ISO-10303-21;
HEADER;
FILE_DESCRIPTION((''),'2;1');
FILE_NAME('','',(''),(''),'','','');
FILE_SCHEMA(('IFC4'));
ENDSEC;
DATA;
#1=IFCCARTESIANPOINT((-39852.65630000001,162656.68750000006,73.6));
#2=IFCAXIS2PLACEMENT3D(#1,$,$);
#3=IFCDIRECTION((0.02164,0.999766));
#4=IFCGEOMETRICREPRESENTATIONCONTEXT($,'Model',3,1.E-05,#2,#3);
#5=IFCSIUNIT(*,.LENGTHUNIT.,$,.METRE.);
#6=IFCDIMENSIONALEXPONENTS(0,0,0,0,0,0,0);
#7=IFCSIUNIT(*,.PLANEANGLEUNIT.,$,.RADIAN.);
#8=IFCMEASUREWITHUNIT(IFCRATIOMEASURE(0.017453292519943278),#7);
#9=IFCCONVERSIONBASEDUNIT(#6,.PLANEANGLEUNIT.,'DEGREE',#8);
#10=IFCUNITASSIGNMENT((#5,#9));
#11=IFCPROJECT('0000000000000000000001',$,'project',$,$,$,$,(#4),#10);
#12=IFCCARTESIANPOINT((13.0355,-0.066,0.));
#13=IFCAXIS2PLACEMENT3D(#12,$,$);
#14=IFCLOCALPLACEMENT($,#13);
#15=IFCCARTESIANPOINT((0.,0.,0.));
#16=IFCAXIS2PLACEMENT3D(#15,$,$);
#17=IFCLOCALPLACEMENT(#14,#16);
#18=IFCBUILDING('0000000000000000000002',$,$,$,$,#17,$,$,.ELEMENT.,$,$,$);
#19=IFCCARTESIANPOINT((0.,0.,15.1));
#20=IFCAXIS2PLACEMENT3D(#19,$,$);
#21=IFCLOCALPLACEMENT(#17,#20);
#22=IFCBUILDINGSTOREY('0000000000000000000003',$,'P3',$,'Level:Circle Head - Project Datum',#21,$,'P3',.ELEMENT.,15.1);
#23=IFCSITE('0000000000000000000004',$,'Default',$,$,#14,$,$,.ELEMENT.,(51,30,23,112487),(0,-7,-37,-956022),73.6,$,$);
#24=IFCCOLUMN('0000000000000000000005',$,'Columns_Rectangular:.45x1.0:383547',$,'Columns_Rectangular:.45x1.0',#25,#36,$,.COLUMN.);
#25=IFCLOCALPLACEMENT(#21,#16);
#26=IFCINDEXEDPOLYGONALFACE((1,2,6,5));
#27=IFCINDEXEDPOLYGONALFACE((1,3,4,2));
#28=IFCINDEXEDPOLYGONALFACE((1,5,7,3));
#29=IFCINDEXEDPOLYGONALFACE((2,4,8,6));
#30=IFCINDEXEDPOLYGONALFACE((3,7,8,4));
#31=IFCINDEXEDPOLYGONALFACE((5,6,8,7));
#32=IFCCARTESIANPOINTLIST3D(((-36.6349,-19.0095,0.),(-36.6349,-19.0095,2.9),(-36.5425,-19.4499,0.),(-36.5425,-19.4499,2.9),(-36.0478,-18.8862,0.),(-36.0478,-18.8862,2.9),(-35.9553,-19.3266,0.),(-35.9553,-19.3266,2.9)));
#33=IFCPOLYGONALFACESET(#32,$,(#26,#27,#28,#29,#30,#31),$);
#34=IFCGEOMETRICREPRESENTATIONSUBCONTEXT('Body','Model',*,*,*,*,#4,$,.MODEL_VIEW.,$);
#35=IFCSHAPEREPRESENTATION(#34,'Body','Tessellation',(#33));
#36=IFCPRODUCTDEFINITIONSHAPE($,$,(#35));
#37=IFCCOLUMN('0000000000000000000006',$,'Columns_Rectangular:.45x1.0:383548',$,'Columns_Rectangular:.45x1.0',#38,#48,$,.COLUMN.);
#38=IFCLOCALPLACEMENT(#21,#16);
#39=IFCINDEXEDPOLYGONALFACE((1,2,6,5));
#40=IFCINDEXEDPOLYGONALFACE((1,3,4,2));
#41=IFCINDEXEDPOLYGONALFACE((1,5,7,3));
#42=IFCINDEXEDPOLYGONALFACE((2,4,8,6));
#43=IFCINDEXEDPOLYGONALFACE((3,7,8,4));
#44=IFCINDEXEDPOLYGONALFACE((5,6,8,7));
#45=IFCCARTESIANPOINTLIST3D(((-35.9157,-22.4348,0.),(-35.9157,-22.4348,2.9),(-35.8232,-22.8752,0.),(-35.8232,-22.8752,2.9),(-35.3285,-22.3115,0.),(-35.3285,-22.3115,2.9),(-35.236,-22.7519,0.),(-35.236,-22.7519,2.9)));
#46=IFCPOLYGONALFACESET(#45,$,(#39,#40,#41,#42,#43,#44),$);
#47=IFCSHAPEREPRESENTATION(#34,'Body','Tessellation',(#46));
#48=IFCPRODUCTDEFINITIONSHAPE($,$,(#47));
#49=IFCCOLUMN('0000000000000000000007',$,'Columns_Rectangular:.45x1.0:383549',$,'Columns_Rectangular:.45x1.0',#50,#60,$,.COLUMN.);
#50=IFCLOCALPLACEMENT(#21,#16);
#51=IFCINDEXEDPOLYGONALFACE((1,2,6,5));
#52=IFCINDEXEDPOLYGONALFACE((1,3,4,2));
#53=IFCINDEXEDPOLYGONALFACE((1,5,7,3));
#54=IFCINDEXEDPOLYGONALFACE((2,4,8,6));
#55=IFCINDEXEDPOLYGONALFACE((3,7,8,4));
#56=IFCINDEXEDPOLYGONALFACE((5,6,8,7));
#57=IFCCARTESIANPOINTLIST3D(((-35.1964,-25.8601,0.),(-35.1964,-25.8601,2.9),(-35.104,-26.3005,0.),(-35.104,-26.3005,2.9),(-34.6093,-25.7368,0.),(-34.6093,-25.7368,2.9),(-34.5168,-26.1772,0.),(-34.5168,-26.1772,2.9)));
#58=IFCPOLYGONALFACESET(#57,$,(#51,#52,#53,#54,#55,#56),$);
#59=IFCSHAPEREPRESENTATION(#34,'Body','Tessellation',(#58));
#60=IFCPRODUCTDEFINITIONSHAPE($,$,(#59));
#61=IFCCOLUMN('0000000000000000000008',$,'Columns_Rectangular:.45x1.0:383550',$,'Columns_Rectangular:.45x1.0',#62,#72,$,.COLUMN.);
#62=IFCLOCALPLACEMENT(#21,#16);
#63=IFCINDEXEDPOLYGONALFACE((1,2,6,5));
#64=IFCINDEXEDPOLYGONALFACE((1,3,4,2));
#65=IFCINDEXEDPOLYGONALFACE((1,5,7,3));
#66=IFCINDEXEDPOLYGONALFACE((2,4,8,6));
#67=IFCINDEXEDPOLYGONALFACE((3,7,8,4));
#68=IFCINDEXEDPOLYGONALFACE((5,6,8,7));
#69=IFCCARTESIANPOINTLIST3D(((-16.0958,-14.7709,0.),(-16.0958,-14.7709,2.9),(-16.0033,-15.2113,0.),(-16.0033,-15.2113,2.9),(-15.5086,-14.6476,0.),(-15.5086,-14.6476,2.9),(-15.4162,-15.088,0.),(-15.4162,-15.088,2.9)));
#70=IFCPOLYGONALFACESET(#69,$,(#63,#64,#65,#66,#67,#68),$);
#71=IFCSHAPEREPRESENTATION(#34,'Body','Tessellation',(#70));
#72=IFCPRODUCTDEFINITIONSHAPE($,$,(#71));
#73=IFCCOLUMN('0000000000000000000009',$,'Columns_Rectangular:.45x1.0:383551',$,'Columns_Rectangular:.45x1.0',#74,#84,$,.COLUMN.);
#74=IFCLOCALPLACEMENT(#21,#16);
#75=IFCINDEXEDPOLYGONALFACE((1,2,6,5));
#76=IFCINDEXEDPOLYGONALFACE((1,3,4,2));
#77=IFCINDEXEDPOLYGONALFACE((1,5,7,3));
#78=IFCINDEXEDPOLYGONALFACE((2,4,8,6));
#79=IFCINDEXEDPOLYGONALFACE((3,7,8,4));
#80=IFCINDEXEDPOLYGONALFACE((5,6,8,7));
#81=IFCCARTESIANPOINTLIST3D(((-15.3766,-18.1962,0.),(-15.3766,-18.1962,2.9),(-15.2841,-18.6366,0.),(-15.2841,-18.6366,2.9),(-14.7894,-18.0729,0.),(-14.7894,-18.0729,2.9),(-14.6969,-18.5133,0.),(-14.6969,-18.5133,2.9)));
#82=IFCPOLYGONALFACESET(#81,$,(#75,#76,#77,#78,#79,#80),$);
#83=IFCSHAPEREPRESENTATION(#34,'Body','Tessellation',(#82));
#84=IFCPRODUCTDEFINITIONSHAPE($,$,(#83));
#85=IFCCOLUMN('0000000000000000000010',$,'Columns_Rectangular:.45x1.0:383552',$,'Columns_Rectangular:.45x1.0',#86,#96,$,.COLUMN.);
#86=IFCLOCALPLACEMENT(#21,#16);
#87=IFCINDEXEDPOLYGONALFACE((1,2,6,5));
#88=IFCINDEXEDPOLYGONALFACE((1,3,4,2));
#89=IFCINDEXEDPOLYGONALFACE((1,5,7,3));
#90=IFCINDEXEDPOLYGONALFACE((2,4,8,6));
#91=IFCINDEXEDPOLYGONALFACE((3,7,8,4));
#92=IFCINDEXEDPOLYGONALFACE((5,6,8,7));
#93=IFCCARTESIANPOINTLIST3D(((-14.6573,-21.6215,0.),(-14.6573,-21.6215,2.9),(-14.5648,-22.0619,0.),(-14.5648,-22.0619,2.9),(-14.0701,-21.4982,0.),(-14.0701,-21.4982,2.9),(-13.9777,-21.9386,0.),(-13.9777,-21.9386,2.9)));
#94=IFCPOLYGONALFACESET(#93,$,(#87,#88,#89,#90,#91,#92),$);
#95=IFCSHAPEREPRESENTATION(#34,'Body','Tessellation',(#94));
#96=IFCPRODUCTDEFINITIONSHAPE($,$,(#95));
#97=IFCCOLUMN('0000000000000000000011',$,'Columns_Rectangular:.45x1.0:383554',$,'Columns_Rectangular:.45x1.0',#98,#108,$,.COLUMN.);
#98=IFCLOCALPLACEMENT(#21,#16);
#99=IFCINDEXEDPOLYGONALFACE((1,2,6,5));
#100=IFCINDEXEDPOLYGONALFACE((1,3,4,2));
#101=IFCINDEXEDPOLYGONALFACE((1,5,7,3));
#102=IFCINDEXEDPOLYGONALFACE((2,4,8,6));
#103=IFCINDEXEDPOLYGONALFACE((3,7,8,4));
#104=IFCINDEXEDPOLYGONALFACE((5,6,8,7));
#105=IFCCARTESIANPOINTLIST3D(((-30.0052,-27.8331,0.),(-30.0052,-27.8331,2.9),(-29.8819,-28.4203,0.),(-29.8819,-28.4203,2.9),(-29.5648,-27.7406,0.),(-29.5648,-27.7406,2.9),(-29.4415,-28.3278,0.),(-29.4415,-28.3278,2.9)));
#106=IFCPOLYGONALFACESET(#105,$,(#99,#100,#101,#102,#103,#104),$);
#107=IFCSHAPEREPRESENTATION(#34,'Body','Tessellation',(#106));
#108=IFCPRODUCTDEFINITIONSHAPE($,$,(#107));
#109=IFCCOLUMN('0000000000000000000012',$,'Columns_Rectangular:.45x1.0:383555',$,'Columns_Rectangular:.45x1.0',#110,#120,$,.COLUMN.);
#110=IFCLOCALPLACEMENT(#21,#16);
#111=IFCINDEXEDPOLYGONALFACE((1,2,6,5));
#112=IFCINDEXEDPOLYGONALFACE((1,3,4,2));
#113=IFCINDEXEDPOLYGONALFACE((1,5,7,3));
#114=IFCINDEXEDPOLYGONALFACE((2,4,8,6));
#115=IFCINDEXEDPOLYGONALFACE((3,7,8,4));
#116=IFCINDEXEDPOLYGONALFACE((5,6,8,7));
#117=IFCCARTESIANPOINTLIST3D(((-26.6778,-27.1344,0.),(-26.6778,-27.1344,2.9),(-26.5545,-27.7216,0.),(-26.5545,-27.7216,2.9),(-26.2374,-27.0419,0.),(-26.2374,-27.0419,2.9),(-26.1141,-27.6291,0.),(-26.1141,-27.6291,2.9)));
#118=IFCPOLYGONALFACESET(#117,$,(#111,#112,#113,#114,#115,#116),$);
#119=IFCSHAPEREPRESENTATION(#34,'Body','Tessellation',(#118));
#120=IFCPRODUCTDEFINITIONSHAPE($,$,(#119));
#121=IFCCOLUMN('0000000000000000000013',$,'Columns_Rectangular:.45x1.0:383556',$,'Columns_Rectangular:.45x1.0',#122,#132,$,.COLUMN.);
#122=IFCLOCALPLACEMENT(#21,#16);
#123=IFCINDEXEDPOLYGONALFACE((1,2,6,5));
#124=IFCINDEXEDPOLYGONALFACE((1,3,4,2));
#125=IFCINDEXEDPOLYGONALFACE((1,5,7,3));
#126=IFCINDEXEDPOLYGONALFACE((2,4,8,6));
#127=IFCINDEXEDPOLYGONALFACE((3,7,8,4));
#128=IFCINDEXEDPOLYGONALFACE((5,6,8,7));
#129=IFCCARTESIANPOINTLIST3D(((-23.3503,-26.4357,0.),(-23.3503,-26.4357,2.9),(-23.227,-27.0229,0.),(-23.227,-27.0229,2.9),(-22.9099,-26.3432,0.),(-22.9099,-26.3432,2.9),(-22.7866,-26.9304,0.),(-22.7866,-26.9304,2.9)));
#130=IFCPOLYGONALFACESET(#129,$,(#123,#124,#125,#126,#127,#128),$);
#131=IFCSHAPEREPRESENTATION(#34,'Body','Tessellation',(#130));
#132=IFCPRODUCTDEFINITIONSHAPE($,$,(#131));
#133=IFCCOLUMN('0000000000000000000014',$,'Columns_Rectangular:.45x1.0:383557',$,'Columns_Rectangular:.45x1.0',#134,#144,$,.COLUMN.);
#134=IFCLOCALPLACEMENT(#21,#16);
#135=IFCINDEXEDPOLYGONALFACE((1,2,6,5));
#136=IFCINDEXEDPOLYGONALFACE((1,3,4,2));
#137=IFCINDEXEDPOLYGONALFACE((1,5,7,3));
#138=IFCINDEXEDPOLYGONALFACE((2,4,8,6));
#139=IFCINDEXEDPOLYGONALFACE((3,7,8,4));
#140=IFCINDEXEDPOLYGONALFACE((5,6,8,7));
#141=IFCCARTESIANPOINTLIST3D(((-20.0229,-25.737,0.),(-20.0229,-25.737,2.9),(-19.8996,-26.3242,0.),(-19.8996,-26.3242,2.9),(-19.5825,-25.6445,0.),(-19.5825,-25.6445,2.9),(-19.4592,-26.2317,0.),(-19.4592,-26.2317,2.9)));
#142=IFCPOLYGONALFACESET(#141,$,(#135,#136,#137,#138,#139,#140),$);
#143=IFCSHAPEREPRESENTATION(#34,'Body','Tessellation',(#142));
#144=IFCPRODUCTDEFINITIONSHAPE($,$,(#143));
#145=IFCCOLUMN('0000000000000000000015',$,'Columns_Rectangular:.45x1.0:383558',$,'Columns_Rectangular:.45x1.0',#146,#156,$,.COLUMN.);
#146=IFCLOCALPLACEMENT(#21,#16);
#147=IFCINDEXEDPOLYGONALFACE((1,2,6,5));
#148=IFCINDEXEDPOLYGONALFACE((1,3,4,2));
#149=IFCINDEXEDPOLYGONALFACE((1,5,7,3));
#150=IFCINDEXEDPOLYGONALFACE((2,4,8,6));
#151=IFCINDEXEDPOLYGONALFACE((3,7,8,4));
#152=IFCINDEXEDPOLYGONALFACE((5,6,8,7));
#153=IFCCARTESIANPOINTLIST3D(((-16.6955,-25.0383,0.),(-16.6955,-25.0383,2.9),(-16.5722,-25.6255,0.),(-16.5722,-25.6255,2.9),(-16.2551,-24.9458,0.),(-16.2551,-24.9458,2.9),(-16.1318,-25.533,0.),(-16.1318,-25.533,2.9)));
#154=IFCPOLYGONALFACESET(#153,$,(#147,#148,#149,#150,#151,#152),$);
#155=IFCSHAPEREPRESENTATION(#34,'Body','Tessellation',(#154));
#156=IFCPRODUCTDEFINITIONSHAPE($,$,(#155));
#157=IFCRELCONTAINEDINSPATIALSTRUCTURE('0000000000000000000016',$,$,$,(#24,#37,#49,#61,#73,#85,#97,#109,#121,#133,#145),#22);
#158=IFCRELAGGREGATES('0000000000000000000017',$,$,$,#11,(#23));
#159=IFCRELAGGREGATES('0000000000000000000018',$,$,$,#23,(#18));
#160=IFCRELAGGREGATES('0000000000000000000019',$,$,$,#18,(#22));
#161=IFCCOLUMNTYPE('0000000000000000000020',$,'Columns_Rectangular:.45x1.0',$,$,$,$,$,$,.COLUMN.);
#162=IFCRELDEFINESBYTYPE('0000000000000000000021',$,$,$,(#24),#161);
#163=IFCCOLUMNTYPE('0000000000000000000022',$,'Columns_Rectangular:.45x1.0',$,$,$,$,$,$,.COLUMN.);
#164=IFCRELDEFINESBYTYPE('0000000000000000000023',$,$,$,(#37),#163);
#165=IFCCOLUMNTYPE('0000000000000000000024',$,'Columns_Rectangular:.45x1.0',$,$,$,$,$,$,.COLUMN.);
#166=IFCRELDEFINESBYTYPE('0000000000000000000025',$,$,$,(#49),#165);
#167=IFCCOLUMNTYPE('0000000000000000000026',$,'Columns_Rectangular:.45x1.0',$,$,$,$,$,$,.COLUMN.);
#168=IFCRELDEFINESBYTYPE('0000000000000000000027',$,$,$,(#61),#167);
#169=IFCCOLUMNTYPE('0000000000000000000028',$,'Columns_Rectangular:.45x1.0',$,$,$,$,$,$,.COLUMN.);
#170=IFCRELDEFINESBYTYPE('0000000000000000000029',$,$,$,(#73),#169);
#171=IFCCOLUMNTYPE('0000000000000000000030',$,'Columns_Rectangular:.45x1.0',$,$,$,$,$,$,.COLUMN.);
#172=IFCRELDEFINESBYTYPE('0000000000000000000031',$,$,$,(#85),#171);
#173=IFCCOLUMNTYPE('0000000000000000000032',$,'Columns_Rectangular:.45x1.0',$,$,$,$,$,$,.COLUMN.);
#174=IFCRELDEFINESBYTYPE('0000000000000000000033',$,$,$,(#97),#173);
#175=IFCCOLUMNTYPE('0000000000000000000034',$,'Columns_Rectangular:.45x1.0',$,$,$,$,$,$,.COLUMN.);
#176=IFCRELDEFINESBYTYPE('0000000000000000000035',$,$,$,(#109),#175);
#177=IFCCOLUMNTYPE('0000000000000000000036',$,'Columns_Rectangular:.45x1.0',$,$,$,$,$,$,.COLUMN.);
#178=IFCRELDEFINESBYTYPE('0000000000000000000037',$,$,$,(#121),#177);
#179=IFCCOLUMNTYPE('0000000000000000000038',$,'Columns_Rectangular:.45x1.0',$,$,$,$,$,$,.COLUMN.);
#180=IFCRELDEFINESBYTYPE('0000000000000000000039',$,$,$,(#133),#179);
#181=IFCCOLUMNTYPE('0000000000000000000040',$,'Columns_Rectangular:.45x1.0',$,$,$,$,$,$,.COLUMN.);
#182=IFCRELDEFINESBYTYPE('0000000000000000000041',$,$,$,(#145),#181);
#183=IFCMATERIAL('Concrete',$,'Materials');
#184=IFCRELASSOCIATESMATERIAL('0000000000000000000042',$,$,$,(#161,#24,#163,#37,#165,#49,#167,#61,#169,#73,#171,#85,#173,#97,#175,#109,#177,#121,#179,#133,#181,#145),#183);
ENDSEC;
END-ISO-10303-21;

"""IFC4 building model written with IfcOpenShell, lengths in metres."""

from ifc_helpers import new_model, entity, si_unit, converted_unit, direction, frame, origin, place, context, subcontext, project, spatial, indexed_curve, outline, extrude, source, transform, mapped, material, type_object, type_shapes, element, save


model = new_model("IFC4")

# Units and contexts
model_context = context("Model", 3, precision=1e-05, world=frame((-39852.65630000001, 162656.68750000006, 73.6)), true_north=direction((0.02164, 0.999766)))
body_context = subcontext(model_context, "Body", "Model", "MODEL_VIEW")
ifc_project = project(units=[si_unit("LENGTHUNIT", "METRE"), converted_unit("PLANEANGLEUNIT", "DEGREE", entity("IfcRatioMeasure", 0.017453292519943278), si_unit("PLANEANGLEUNIT", "RADIAN"), dimensions=[0, 0, 0, 0, 0, 0, 0])], contexts=[model_context])

# Site, building, storey
site_placement = place(None, frame((13.0355, -0.066, 0.0)))
site = spatial("IfcSite", under=ifc_project, at=site_placement, Name="Default", CompositionType="ELEMENT", RefLatitude=(51, 30, 23, 112487), RefLongitude=(0, -7, -37, -956022), RefElevation=73.6)
building_placement = place(site_placement, origin())
building = spatial("IfcBuilding", under=site, at=building_placement, CompositionType="ELEMENT")
storey_placement = place(building_placement, frame((0.0, 0.0, 15.1)))
storey = spatial("IfcBuildingStorey", under=building, at=storey_placement, Name="P3", ObjectType="Level:Circle Head - Project Datum", LongName="P3", CompositionType="ELEMENT", Elevation=15.1)

# Columns
ifc_material = material(Name="Concrete", Category="Materials")
column_type_1 = type_object("IfcColumnType", Name="Columns_Rectangular:.45x1.0", PredefinedType="COLUMN", material=ifc_material)
shared_shape_1 = source(origin(), body_context, "Body", "SweptSolid", [
    extrude(outline(indexed_curve([(-0.3, -0.225), (0.3, -0.225), (0.3, 0.225), (-0.3, 0.225), (-0.3, -0.225)], self_intersect=False)), frame((-36.2951, -19.168, 15.1), z_axis=(0.0, 0.0, 1.0), x_axis=(-0.978657, -0.2055, 0.0)), (0.0, 0.0, 1.0), 2.9),
])
type_shapes(column_type_1, [shared_shape_1])
column_1_placement = place(storey_placement, frame((0.0, 0.0, -15.1)))
element("IfcColumn", 1, at=column_1_placement, inside=storey, type_object=column_type_1, material=ifc_material, Name="Columns_Rectangular:.45x1.0:383547", ObjectType="Columns_Rectangular:.45x1.0", PredefinedType="COLUMN", context=body_context, shape_type="MappedRepresentation", body=[
    mapped(shared_shape_1, transform((0.0, 0.0, 0.0), scale=1.0)),
])
column_type_2 = type_object("IfcColumnType", Name="Columns_Rectangular:.45x1.0", PredefinedType="COLUMN", material=ifc_material)
shared_shape_2 = source(origin(), body_context, "Body", "SweptSolid", [
    extrude(outline(indexed_curve([(-0.3, -0.225), (0.3, -0.225), (0.3, 0.225), (-0.3, 0.225), (-0.3, -0.225)], self_intersect=False)), frame((-35.5759, -22.5933, 15.1), z_axis=(0.0, 0.0, 1.0), x_axis=(-0.978657, -0.2055, 0.0)), (0.0, 0.0, 1.0), 2.9),
])
type_shapes(column_type_2, [shared_shape_2])
column_2_placement = place(storey_placement, frame((0.0, 0.0, -15.1)))
element("IfcColumn", 2, at=column_2_placement, inside=storey, type_object=column_type_2, material=ifc_material, Name="Columns_Rectangular:.45x1.0:383548", ObjectType="Columns_Rectangular:.45x1.0", PredefinedType="COLUMN", context=body_context, shape_type="MappedRepresentation", body=[
    mapped(shared_shape_2, transform((0.0, 0.0, 0.0), scale=1.0)),
])
column_type_3 = type_object("IfcColumnType", Name="Columns_Rectangular:.45x1.0", PredefinedType="COLUMN", material=ifc_material)
shared_shape_3 = source(origin(), body_context, "Body", "SweptSolid", [
    extrude(outline(indexed_curve([(-0.3, -0.225), (0.3, -0.225), (0.3, 0.225), (-0.3, 0.225), (-0.3, -0.225)], self_intersect=False)), frame((-34.8566, -26.0186, 15.1), z_axis=(0.0, 0.0, 1.0), x_axis=(-0.978657, -0.2055, 0.0)), (0.0, 0.0, 1.0), 2.9),
])
type_shapes(column_type_3, [shared_shape_3])
column_3_placement = place(storey_placement, frame((0.0, 0.0, -15.1)))
element("IfcColumn", 3, at=column_3_placement, inside=storey, type_object=column_type_3, material=ifc_material, Name="Columns_Rectangular:.45x1.0:383549", ObjectType="Columns_Rectangular:.45x1.0", PredefinedType="COLUMN", context=body_context, shape_type="MappedRepresentation", body=[
    mapped(shared_shape_3, transform((0.0, 0.0, 0.0), scale=1.0)),
])
column_type_4 = type_object("IfcColumnType", Name="Columns_Rectangular:.45x1.0", PredefinedType="COLUMN", material=ifc_material)
shared_shape_4 = source(origin(), body_context, "Body", "SweptSolid", [
    extrude(outline(indexed_curve([(-0.3, -0.225), (0.3, -0.225), (0.3, 0.225), (-0.3, 0.225), (-0.3, -0.225)], self_intersect=False)), frame((-15.756, -14.9295, 15.1), z_axis=(0.0, 0.0, 1.0), x_axis=(-0.978657, -0.2055, 0.0)), (0.0, 0.0, 1.0), 2.9),
])
type_shapes(column_type_4, [shared_shape_4])
column_4_placement = place(storey_placement, frame((0.0, 0.0, -15.1)))
element("IfcColumn", 4, at=column_4_placement, inside=storey, type_object=column_type_4, material=ifc_material, Name="Columns_Rectangular:.45x1.0:383550", ObjectType="Columns_Rectangular:.45x1.0", PredefinedType="COLUMN", context=body_context, shape_type="MappedRepresentation", body=[
    mapped(shared_shape_4, transform((0.0, 0.0, 0.0), scale=1.0)),
])
column_type_5 = type_object("IfcColumnType", Name="Columns_Rectangular:.45x1.0", PredefinedType="COLUMN", material=ifc_material)
shared_shape_5 = source(origin(), body_context, "Body", "SweptSolid", [
    extrude(outline(indexed_curve([(-0.3, -0.225), (0.3, -0.225), (0.3, 0.225), (-0.3, 0.225), (-0.3, -0.225)], self_intersect=False)), frame((-15.0367, -18.3548, 15.1), z_axis=(0.0, 0.0, 1.0), x_axis=(-0.978657, -0.2055, 0.0)), (0.0, 0.0, 1.0), 2.9),
])
type_shapes(column_type_5, [shared_shape_5])
column_5_placement = place(storey_placement, frame((0.0, 0.0, -15.1)))
element("IfcColumn", 5, at=column_5_placement, inside=storey, type_object=column_type_5, material=ifc_material, Name="Columns_Rectangular:.45x1.0:383551", ObjectType="Columns_Rectangular:.45x1.0", PredefinedType="COLUMN", context=body_context, shape_type="MappedRepresentation", body=[
    mapped(shared_shape_5, transform((0.0, 0.0, 0.0), scale=1.0)),
])
column_type_6 = type_object("IfcColumnType", Name="Columns_Rectangular:.45x1.0", PredefinedType="COLUMN", material=ifc_material)
shared_shape_6 = source(origin(), body_context, "Body", "SweptSolid", [
    extrude(outline(indexed_curve([(-0.3, -0.225), (0.3, -0.225), (0.3, 0.225), (-0.3, 0.225), (-0.3, -0.225)], self_intersect=False)), frame((-14.3175, -21.7801, 15.1), z_axis=(0.0, 0.0, 1.0), x_axis=(-0.978657, -0.2055, 0.0)), (0.0, 0.0, 1.0), 2.9),
])
type_shapes(column_type_6, [shared_shape_6])
column_6_placement = place(storey_placement, frame((0.0, 0.0, -15.1)))
element("IfcColumn", 6, at=column_6_placement, inside=storey, type_object=column_type_6, material=ifc_material, Name="Columns_Rectangular:.45x1.0:383552", ObjectType="Columns_Rectangular:.45x1.0", PredefinedType="COLUMN", context=body_context, shape_type="MappedRepresentation", body=[
    mapped(shared_shape_6, transform((0.0, 0.0, 0.0), scale=1.0)),
])
column_type_7 = type_object("IfcColumnType", Name="Columns_Rectangular:.45x1.0", PredefinedType="COLUMN", material=ifc_material)
shared_shape_7 = source(origin(), body_context, "Body", "SweptSolid", [
    extrude(outline(indexed_curve([(-0.3, -0.225), (0.3, -0.225), (0.3, 0.225), (-0.3, 0.225), (-0.3, -0.225)], self_intersect=False)), frame((-29.7234, -28.0804, 15.1), z_axis=(0.0, 0.0, 1.0), x_axis=(-0.2055, 0.978657, 0.0)), (0.0, 0.0, 1.0), 2.9),
])
type_shapes(column_type_7, [shared_shape_7])
column_7_placement = place(storey_placement, frame((0.0, 0.0, -15.1)))
element("IfcColumn", 7, at=column_7_placement, inside=storey, type_object=column_type_7, material=ifc_material, Name="Columns_Rectangular:.45x1.0:383554", ObjectType="Columns_Rectangular:.45x1.0", PredefinedType="COLUMN", context=body_context, shape_type="MappedRepresentation", body=[
    mapped(shared_shape_7, transform((0.0, 0.0, 0.0), scale=1.0)),
])
column_type_8 = type_object("IfcColumnType", Name="Columns_Rectangular:.45x1.0", PredefinedType="COLUMN", material=ifc_material)
shared_shape_8 = source(origin(), body_context, "Body", "SweptSolid", [
    extrude(outline(indexed_curve([(-0.3, -0.225), (0.3, -0.225), (0.3, 0.225), (-0.3, 0.225), (-0.3, -0.225)], self_intersect=False)), frame((-26.3959, -27.3817, 15.1), z_axis=(0.0, 0.0, 1.0), x_axis=(-0.2055, 0.978657, 0.0)), (0.0, 0.0, 1.0), 2.9),
])
type_shapes(column_type_8, [shared_shape_8])
column_8_placement = place(storey_placement, frame((0.0, 0.0, -15.1)))
element("IfcColumn", 8, at=column_8_placement, inside=storey, type_object=column_type_8, material=ifc_material, Name="Columns_Rectangular:.45x1.0:383555", ObjectType="Columns_Rectangular:.45x1.0", PredefinedType="COLUMN", context=body_context, shape_type="MappedRepresentation", body=[
    mapped(shared_shape_8, transform((0.0, 0.0, 0.0), scale=1.0)),
])
column_type_9 = type_object("IfcColumnType", Name="Columns_Rectangular:.45x1.0", PredefinedType="COLUMN", material=ifc_material)
shared_shape_9 = source(origin(), body_context, "Body", "SweptSolid", [
    extrude(outline(indexed_curve([(-0.3, -0.225), (0.3, -0.225), (0.3, 0.225), (-0.3, 0.225), (-0.3, -0.225)], self_intersect=False)), frame((-23.0685, -26.6831, 15.1), z_axis=(0.0, 0.0, 1.0), x_axis=(-0.2055, 0.978657, 0.0)), (0.0, 0.0, 1.0), 2.9),
])
type_shapes(column_type_9, [shared_shape_9])
column_9_placement = place(storey_placement, frame((0.0, 0.0, -15.1)))
element("IfcColumn", 9, at=column_9_placement, inside=storey, type_object=column_type_9, material=ifc_material, Name="Columns_Rectangular:.45x1.0:383556", ObjectType="Columns_Rectangular:.45x1.0", PredefinedType="COLUMN", context=body_context, shape_type="MappedRepresentation", body=[
    mapped(shared_shape_9, transform((0.0, 0.0, 0.0), scale=1.0)),
])
column_type_10 = type_object("IfcColumnType", Name="Columns_Rectangular:.45x1.0", PredefinedType="COLUMN", material=ifc_material)
shared_shape_10 = source(origin(), body_context, "Body", "SweptSolid", [
    extrude(outline(indexed_curve([(-0.3, -0.225), (0.3, -0.225), (0.3, 0.225), (-0.3, 0.225), (-0.3, -0.225)], self_intersect=False)), frame((-19.741, -25.9844, 15.1), z_axis=(0.0, 0.0, 1.0), x_axis=(-0.2055, 0.978657, 0.0)), (0.0, 0.0, 1.0), 2.9),
])
type_shapes(column_type_10, [shared_shape_10])
column_10_placement = place(storey_placement, frame((0.0, 0.0, -15.1)))
element("IfcColumn", 10, at=column_10_placement, inside=storey, type_object=column_type_10, material=ifc_material, Name="Columns_Rectangular:.45x1.0:383557", ObjectType="Columns_Rectangular:.45x1.0", PredefinedType="COLUMN", context=body_context, shape_type="MappedRepresentation", body=[
    mapped(shared_shape_10, transform((0.0, 0.0, 0.0), scale=1.0)),
])
column_type_11 = type_object("IfcColumnType", Name="Columns_Rectangular:.45x1.0", PredefinedType="COLUMN", material=ifc_material)
shared_shape_11 = source(origin(), body_context, "Body", "SweptSolid", [
    extrude(outline(indexed_curve([(-0.3, -0.225), (0.3, -0.225), (0.3, 0.225), (-0.3, 0.225), (-0.3, -0.225)], self_intersect=False)), frame((-16.4136, -25.2857, 15.1), z_axis=(0.0, 0.0, 1.0), x_axis=(-0.2055, 0.978657, 0.0)), (0.0, 0.0, 1.0), 2.9),
])
type_shapes(column_type_11, [shared_shape_11])
column_11_placement = place(storey_placement, frame((0.0, 0.0, -15.1)))
element("IfcColumn", 11, at=column_11_placement, inside=storey, type_object=column_type_11, material=ifc_material, Name="Columns_Rectangular:.45x1.0:383558", ObjectType="Columns_Rectangular:.45x1.0", PredefinedType="COLUMN", context=body_context, shape_type="MappedRepresentation", body=[
    mapped(shared_shape_11, transform((0.0, 0.0, 0.0), scale=1.0)),
])

save(model, "model.ifc")
